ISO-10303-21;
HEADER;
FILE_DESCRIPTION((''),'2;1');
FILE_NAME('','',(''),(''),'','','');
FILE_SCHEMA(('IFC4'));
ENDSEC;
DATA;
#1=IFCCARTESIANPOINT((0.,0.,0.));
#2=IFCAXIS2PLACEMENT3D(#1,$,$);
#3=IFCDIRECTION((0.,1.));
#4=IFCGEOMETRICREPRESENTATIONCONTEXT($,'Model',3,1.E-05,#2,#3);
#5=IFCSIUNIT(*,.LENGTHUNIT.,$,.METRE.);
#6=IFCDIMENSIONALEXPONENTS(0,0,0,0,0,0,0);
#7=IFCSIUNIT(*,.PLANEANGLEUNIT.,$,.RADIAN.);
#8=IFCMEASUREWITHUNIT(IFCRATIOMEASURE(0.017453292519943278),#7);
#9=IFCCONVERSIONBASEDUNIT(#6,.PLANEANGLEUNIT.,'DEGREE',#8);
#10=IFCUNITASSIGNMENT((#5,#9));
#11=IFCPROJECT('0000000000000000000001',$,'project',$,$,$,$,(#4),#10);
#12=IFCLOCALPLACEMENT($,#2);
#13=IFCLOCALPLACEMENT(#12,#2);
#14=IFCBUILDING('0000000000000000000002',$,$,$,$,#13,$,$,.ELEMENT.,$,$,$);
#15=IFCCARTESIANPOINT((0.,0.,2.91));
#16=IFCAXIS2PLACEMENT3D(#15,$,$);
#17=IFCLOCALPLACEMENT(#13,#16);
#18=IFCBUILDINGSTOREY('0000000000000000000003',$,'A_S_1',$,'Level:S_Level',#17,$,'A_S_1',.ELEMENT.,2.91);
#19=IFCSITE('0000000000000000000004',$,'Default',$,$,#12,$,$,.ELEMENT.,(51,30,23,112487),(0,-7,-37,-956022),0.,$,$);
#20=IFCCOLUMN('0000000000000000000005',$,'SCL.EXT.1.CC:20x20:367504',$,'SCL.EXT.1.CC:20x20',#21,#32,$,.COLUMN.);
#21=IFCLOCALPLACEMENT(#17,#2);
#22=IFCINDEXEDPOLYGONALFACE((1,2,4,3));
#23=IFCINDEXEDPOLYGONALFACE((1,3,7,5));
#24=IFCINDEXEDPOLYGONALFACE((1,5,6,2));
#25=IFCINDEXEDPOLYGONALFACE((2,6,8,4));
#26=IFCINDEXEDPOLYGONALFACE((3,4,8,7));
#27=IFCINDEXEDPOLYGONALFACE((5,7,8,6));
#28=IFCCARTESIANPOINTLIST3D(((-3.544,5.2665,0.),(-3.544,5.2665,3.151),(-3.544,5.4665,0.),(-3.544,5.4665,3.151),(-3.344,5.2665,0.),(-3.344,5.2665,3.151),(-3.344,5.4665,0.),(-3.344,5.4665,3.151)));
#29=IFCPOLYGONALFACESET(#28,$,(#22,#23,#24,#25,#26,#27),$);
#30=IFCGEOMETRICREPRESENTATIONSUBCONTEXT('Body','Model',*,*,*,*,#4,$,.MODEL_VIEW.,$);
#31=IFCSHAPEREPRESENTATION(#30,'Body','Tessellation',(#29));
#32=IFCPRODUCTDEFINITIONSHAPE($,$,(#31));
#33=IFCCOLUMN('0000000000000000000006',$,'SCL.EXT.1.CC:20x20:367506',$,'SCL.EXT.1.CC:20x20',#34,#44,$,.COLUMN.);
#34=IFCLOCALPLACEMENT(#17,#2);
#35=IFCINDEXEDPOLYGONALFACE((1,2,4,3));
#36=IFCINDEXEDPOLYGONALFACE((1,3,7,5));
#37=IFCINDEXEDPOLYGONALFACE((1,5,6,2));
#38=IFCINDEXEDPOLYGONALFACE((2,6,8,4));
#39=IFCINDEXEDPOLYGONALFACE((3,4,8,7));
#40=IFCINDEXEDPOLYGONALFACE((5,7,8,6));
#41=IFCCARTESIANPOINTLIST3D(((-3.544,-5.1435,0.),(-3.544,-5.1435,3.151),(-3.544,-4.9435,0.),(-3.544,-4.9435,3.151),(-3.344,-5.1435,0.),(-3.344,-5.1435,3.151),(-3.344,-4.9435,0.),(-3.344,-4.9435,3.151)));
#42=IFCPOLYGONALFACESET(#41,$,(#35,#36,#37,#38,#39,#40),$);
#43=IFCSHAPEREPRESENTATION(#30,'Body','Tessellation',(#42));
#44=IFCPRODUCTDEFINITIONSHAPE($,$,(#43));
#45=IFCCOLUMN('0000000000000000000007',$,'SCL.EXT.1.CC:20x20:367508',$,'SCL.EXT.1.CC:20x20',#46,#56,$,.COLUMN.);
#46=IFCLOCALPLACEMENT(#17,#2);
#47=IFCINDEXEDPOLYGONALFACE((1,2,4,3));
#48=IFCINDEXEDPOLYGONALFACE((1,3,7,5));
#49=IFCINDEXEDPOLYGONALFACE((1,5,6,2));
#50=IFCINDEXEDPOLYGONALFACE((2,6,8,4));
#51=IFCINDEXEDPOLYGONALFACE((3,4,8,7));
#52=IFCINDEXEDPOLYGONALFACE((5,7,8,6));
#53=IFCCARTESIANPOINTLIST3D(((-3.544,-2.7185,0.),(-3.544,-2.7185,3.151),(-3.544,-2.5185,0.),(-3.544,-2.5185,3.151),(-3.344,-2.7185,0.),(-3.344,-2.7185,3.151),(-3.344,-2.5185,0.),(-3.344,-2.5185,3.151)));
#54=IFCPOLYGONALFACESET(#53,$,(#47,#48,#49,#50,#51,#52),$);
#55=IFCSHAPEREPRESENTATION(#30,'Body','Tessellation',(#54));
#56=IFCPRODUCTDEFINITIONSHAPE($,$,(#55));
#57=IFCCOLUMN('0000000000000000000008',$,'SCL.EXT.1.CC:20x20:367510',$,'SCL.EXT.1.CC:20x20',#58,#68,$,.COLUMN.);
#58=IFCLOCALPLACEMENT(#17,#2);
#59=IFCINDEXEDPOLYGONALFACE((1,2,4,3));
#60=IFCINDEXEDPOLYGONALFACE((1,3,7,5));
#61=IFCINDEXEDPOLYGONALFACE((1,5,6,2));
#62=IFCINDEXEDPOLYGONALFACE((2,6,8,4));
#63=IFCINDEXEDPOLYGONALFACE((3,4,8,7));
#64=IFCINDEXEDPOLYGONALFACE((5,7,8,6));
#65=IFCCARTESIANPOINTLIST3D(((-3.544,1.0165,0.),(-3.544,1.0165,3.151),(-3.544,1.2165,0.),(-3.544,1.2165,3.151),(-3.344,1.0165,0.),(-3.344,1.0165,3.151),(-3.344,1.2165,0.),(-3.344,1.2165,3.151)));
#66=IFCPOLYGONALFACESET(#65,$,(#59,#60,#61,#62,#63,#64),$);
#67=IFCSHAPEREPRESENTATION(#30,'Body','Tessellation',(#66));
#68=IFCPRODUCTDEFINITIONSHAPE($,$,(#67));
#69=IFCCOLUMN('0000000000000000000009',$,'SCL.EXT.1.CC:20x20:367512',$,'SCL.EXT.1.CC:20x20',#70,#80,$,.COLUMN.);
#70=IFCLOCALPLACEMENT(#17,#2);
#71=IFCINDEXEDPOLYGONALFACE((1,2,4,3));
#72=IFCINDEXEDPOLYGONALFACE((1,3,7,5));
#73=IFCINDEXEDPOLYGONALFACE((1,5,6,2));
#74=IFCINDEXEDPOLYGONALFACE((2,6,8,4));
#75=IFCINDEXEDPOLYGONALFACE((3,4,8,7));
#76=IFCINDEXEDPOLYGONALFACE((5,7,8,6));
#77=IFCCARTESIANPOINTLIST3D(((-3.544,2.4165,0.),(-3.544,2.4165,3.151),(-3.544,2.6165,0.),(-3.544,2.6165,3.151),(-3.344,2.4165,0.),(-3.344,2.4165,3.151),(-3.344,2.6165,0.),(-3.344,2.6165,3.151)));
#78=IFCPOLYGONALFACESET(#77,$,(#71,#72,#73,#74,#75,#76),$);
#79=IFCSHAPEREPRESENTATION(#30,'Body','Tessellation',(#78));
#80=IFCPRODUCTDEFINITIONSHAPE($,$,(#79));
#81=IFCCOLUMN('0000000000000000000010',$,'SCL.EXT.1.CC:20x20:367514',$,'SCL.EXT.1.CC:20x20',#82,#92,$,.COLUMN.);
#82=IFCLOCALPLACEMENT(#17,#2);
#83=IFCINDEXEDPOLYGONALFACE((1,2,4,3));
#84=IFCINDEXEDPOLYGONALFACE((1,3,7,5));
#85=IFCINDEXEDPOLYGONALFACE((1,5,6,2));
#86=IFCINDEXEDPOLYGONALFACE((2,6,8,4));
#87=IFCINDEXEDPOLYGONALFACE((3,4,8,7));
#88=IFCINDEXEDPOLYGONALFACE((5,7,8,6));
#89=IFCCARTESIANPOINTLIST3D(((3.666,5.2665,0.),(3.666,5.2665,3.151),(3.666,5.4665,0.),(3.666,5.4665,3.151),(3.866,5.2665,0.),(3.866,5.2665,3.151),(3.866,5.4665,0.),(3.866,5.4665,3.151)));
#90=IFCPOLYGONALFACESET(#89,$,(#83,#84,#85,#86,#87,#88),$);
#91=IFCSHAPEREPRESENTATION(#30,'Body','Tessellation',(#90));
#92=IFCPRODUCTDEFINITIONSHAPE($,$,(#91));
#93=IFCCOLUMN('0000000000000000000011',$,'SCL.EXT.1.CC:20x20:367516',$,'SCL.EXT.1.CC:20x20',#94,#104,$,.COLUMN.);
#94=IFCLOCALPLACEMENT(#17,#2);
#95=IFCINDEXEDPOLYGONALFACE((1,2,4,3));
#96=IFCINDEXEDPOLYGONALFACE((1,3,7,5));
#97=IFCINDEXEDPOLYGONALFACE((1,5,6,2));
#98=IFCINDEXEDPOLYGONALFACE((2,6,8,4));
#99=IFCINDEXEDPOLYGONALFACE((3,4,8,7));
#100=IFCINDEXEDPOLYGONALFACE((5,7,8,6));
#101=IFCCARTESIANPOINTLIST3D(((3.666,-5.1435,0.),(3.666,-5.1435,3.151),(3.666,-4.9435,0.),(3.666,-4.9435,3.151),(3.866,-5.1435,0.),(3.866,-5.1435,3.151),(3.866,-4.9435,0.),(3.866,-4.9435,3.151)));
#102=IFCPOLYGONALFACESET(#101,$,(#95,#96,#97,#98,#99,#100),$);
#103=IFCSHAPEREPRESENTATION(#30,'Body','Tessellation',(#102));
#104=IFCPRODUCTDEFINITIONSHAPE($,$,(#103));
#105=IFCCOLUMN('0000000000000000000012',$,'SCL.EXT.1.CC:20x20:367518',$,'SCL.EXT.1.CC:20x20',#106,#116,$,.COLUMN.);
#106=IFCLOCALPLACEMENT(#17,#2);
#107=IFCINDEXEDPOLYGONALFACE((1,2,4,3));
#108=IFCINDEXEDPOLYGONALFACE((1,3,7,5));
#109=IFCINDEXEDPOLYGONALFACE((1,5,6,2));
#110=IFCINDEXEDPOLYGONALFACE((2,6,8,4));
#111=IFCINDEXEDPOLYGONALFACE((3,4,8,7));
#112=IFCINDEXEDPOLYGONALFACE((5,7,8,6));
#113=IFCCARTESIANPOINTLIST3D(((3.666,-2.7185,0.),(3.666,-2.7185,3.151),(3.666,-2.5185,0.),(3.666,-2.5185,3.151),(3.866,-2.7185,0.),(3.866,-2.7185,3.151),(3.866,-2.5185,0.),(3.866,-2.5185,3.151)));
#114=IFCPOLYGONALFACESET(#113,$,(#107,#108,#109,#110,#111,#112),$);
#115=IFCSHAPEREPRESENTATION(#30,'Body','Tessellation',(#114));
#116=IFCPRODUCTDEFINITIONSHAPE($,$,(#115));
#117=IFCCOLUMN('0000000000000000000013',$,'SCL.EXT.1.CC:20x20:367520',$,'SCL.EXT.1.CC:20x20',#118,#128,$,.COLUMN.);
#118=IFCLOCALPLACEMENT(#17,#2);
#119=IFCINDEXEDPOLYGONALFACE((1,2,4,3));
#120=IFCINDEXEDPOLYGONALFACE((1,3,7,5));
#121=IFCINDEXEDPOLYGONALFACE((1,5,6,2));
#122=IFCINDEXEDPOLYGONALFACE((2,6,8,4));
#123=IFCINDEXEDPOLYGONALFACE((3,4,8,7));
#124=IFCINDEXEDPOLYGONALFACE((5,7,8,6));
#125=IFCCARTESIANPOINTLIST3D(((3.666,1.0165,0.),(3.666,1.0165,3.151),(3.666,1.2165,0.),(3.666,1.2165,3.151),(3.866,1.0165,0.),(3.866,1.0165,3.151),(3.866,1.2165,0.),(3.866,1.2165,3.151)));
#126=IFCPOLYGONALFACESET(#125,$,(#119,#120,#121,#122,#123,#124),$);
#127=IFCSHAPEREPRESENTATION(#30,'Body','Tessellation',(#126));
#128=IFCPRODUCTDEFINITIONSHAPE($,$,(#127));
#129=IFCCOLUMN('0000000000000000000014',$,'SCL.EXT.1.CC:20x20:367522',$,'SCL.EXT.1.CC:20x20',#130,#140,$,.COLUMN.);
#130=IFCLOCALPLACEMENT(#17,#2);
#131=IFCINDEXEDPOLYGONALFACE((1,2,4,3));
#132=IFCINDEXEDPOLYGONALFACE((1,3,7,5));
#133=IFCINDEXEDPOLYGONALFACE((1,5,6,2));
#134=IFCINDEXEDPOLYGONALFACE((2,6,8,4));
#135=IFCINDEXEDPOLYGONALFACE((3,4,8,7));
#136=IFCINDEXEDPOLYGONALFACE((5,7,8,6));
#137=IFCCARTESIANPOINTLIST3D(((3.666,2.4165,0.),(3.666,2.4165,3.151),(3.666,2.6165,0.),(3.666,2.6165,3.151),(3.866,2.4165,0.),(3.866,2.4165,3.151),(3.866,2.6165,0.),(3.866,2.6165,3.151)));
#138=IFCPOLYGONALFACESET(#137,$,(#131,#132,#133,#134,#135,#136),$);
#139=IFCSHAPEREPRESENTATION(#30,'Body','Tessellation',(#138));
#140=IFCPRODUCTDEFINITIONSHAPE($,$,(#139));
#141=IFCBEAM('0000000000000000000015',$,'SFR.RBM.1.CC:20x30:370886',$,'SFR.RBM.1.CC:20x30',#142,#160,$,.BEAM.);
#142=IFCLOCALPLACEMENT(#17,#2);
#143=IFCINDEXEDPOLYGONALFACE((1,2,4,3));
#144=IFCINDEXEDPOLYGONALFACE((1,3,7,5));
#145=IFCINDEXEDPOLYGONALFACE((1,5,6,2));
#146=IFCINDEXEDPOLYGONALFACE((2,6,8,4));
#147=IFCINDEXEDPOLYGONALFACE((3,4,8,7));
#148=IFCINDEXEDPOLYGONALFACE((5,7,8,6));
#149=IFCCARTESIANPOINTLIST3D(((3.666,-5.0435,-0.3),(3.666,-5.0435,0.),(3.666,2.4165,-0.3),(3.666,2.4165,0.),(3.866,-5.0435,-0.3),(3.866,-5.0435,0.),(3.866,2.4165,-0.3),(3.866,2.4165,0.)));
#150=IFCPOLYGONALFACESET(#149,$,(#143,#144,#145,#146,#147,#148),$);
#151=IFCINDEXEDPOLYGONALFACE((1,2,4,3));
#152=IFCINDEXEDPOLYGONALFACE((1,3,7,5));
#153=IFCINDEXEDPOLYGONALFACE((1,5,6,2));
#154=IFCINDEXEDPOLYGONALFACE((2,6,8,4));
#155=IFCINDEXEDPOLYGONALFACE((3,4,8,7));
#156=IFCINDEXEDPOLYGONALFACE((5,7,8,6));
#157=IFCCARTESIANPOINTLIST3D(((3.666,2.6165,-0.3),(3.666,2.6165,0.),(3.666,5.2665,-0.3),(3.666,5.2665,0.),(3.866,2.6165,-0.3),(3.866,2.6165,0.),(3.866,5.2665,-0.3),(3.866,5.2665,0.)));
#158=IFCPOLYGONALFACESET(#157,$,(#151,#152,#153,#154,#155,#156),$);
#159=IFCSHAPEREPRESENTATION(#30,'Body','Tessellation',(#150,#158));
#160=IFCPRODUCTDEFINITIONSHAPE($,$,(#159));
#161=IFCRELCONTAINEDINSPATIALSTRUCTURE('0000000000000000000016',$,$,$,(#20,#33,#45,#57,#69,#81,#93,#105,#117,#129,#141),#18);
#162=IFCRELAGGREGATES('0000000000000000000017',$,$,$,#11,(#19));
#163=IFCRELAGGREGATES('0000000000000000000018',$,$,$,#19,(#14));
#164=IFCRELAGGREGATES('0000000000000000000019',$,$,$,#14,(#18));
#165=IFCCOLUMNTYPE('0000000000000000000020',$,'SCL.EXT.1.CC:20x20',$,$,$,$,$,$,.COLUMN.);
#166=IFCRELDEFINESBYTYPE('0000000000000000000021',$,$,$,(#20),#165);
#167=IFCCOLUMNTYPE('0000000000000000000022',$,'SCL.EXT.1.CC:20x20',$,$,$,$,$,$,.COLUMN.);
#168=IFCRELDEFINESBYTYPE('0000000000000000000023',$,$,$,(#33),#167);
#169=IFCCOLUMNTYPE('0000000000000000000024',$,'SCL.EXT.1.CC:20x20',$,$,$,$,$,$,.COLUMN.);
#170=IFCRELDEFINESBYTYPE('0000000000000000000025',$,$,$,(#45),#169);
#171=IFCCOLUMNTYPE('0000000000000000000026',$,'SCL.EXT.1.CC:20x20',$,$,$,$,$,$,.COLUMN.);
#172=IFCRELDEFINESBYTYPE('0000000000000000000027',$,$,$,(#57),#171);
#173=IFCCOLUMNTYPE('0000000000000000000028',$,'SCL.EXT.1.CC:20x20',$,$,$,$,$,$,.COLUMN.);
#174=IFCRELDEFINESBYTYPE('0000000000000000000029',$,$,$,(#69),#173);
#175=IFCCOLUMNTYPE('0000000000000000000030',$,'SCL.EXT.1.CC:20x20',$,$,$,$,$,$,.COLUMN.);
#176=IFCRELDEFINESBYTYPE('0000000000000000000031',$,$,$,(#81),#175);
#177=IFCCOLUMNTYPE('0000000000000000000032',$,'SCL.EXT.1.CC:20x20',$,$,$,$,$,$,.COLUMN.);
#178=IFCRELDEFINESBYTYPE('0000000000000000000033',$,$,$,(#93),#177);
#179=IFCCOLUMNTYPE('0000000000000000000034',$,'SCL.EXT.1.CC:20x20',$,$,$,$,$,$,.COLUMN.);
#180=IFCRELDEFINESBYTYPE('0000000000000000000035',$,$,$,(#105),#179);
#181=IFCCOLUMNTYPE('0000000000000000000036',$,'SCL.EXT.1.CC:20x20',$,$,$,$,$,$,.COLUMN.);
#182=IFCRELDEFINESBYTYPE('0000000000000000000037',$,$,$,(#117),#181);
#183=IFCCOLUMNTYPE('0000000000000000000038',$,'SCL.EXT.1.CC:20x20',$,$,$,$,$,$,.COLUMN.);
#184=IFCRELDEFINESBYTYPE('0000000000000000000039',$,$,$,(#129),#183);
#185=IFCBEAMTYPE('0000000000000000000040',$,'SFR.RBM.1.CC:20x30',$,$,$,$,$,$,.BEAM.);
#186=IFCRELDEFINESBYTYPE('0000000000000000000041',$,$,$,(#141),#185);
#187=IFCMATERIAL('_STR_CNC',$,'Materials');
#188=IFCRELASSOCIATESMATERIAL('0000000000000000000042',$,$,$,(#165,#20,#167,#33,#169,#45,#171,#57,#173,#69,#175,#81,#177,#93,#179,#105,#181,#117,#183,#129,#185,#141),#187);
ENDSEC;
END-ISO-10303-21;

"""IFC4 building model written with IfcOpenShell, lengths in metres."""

from ifc_helpers import new_model, entity, si_unit, converted_unit, direction, frame, origin, place, context, subcontext, project, spatial, indexed_curve, outline, extrude, source, transform, mapped, material, type_object, type_shapes, element, save


model = new_model("IFC4")

# Units and contexts
model_context = context("Model", 3, precision=1e-05, world=origin(), true_north=direction((0.0, 1.0)))
body_context = subcontext(model_context, "Body", "Model", "MODEL_VIEW")
ifc_project = project(units=[si_unit("LENGTHUNIT", "METRE"), converted_unit("PLANEANGLEUNIT", "DEGREE", entity("IfcRatioMeasure", 0.017453292519943278), si_unit("PLANEANGLEUNIT", "RADIAN"), dimensions=[0, 0, 0, 0, 0, 0, 0])], contexts=[model_context])

# Site, building, storey
site_placement = place(None, origin())
site = spatial("IfcSite", under=ifc_project, at=site_placement, Name="Default", CompositionType="ELEMENT", RefLatitude=(51, 30, 23, 112487), RefLongitude=(0, -7, -37, -956022), RefElevation=0.0)
building_placement = place(site_placement, origin())
building = spatial("IfcBuilding", under=site, at=building_placement, CompositionType="ELEMENT")
storey_placement = place(building_placement, frame((0.0, 0.0, 2.91)))
storey = spatial("IfcBuildingStorey", under=building, at=storey_placement, Name="A_S_1", ObjectType="Level:S_Level", LongName="A_S_1", CompositionType="ELEMENT", Elevation=2.91)

# Columns
ifc_material_1 = material(Name="_STR_CNC", Category="Materials")
column_type_1 = type_object("IfcColumnType", Name="SCL.EXT.1.CC:20x20", PredefinedType="COLUMN", material=ifc_material_1)
shared_shape_1 = source(origin(), body_context, "Body", "SweptSolid", [
    extrude(outline(indexed_curve([(-0.1, -0.1), (0.1, -0.1), (0.1, 0.1), (-0.1, 0.1), (-0.1, -0.1)], self_intersect=False)), frame((-3.444, 5.3665, 2.91), z_axis=(0.0, 0.0, 1.0), x_axis=(0.0, -1.0, 0.0)), (0.0, 0.0, 1.0), 3.151),
])
type_shapes(column_type_1, [shared_shape_1])
column_1_placement = place(storey_placement, frame((0.0, 0.0, -2.91)))
element("IfcColumn", 1, at=column_1_placement, inside=storey, type_object=column_type_1, material=ifc_material_1, Name="SCL.EXT.1.CC:20x20:367504", ObjectType="SCL.EXT.1.CC:20x20", PredefinedType="COLUMN", context=body_context, shape_type="MappedRepresentation", body=[
    mapped(shared_shape_1, transform((0.0, 0.0, 0.0), scale=1.0)),
])
column_type_2 = type_object("IfcColumnType", Name="SCL.EXT.1.CC:20x20", PredefinedType="COLUMN", material=ifc_material_1)
shared_shape_2 = source(origin(), body_context, "Body", "SweptSolid", [
    extrude(outline(indexed_curve([(-0.1, -0.1), (0.1, -0.1), (0.1, 0.1), (-0.1, 0.1), (-0.1, -0.1)], self_intersect=False)), frame((-3.444, -5.0435, 2.91), z_axis=(0.0, 0.0, 1.0), x_axis=(0.0, -1.0, 0.0)), (0.0, 0.0, 1.0), 3.151),
])
type_shapes(column_type_2, [shared_shape_2])
column_2_placement = place(storey_placement, frame((0.0, 0.0, -2.91)))
element("IfcColumn", 2, at=column_2_placement, inside=storey, type_object=column_type_2, material=ifc_material_1, Name="SCL.EXT.1.CC:20x20:367506", ObjectType="SCL.EXT.1.CC:20x20", PredefinedType="COLUMN", context=body_context, shape_type="MappedRepresentation", body=[
    mapped(shared_shape_2, transform((0.0, 0.0, 0.0), scale=1.0)),
])
column_type_3 = type_object("IfcColumnType", Name="SCL.EXT.1.CC:20x20", PredefinedType="COLUMN", material=ifc_material_1)
shared_shape_3 = source(origin(), body_context, "Body", "SweptSolid", [
    extrude(outline(indexed_curve([(-0.1, -0.1), (0.1, -0.1), (0.1, 0.1), (-0.1, 0.1), (-0.1, -0.1)], self_intersect=False)), frame((-3.444, -2.6185, 2.91), z_axis=(0.0, 0.0, 1.0), x_axis=(0.0, -1.0, 0.0)), (0.0, 0.0, 1.0), 3.151),
])
type_shapes(column_type_3, [shared_shape_3])
column_3_placement = place(storey_placement, frame((0.0, 0.0, -2.91)))
element("IfcColumn", 3, at=column_3_placement, inside=storey, type_object=column_type_3, material=ifc_material_1, Name="SCL.EXT.1.CC:20x20:367508", ObjectType="SCL.EXT.1.CC:20x20", PredefinedType="COLUMN", context=body_context, shape_type="MappedRepresentation", body=[
    mapped(shared_shape_3, transform((0.0, 0.0, 0.0), scale=1.0)),
])
column_type_4 = type_object("IfcColumnType", Name="SCL.EXT.1.CC:20x20", PredefinedType="COLUMN", material=ifc_material_1)
shared_shape_4 = source(origin(), body_context, "Body", "SweptSolid", [
    extrude(outline(indexed_curve([(-0.1, -0.1), (0.1, -0.1), (0.1, 0.1), (-0.1, 0.1), (-0.1, -0.1)], self_intersect=False)), frame((-3.444, 1.1165, 2.91), z_axis=(0.0, 0.0, 1.0), x_axis=(0.0, -1.0, 0.0)), (0.0, 0.0, 1.0), 3.151),
])
type_shapes(column_type_4, [shared_shape_4])
column_4_placement = place(storey_placement, frame((0.0, 0.0, -2.91)))
element("IfcColumn", 4, at=column_4_placement, inside=storey, type_object=column_type_4, material=ifc_material_1, Name="SCL.EXT.1.CC:20x20:367510", ObjectType="SCL.EXT.1.CC:20x20", PredefinedType="COLUMN", context=body_context, shape_type="MappedRepresentation", body=[
    mapped(shared_shape_4, transform((0.0, 0.0, 0.0), scale=1.0)),
])
column_type_5 = type_object("IfcColumnType", Name="SCL.EXT.1.CC:20x20", PredefinedType="COLUMN", material=ifc_material_1)
shared_shape_5 = source(origin(), body_context, "Body", "SweptSolid", [
    extrude(outline(indexed_curve([(-0.1, -0.1), (0.1, -0.1), (0.1, 0.1), (-0.1, 0.1), (-0.1, -0.1)], self_intersect=False)), frame((-3.444, 2.5165, 2.91), z_axis=(0.0, 0.0, 1.0), x_axis=(0.0, -1.0, 0.0)), (0.0, 0.0, 1.0), 3.151),
])
type_shapes(column_type_5, [shared_shape_5])
column_5_placement = place(storey_placement, frame((0.0, 0.0, -2.91)))
element("IfcColumn", 5, at=column_5_placement, inside=storey, type_object=column_type_5, material=ifc_material_1, Name="SCL.EXT.1.CC:20x20:367512", ObjectType="SCL.EXT.1.CC:20x20", PredefinedType="COLUMN", context=body_context, shape_type="MappedRepresentation", body=[
    mapped(shared_shape_5, transform((0.0, 0.0, 0.0), scale=1.0)),
])
column_type_6 = type_object("IfcColumnType", Name="SCL.EXT.1.CC:20x20", PredefinedType="COLUMN", material=ifc_material_1)
shared_shape_6 = source(origin(), body_context, "Body", "SweptSolid", [
    extrude(outline(indexed_curve([(-0.1, -0.1), (0.1, -0.1), (0.1, 0.1), (-0.1, 0.1), (-0.1, -0.1)], self_intersect=False)), frame((3.766, 5.3665, 2.91), z_axis=(0.0, 0.0, 1.0), x_axis=(0.0, -1.0, 0.0)), (0.0, 0.0, 1.0), 3.151),
])
type_shapes(column_type_6, [shared_shape_6])
column_6_placement = place(storey_placement, frame((0.0, 0.0, -2.91)))
element("IfcColumn", 6, at=column_6_placement, inside=storey, type_object=column_type_6, material=ifc_material_1, Name="SCL.EXT.1.CC:20x20:367514", ObjectType="SCL.EXT.1.CC:20x20", PredefinedType="COLUMN", context=body_context, shape_type="MappedRepresentation", body=[
    mapped(shared_shape_6, transform((0.0, 0.0, 0.0), scale=1.0)),
])
column_type_7 = type_object("IfcColumnType", Name="SCL.EXT.1.CC:20x20", PredefinedType="COLUMN", material=ifc_material_1)
shared_shape_7 = source(origin(), body_context, "Body", "SweptSolid", [
    extrude(outline(indexed_curve([(-0.1, -0.1), (0.1, -0.1), (0.1, 0.1), (-0.1, 0.1), (-0.1, -0.1)], self_intersect=False)), frame((3.766, -5.0435, 2.91), z_axis=(0.0, 0.0, 1.0), x_axis=(0.0, -1.0, 0.0)), (0.0, 0.0, 1.0), 3.151),
])
type_shapes(column_type_7, [shared_shape_7])
column_7_placement = place(storey_placement, frame((0.0, 0.0, -2.91)))
element("IfcColumn", 7, at=column_7_placement, inside=storey, type_object=column_type_7, material=ifc_material_1, Name="SCL.EXT.1.CC:20x20:367516", ObjectType="SCL.EXT.1.CC:20x20", PredefinedType="COLUMN", context=body_context, shape_type="MappedRepresentation", body=[
    mapped(shared_shape_7, transform((0.0, 0.0, 0.0), scale=1.0)),
])
column_type_8 = type_object("IfcColumnType", Name="SCL.EXT.1.CC:20x20", PredefinedType="COLUMN", material=ifc_material_1)
shared_shape_8 = source(origin(), body_context, "Body", "SweptSolid", [
    extrude(outline(indexed_curve([(-0.1, -0.1), (0.1, -0.1), (0.1, 0.1), (-0.1, 0.1), (-0.1, -0.1)], self_intersect=False)), frame((3.766, -2.6185, 2.91), z_axis=(0.0, 0.0, 1.0), x_axis=(0.0, -1.0, 0.0)), (0.0, 0.0, 1.0), 3.151),
])
type_shapes(column_type_8, [shared_shape_8])
column_8_placement = place(storey_placement, frame((0.0, 0.0, -2.91)))
element("IfcColumn", 8, at=column_8_placement, inside=storey, type_object=column_type_8, material=ifc_material_1, Name="SCL.EXT.1.CC:20x20:367518", ObjectType="SCL.EXT.1.CC:20x20", PredefinedType="COLUMN", context=body_context, shape_type="MappedRepresentation", body=[
    mapped(shared_shape_8, transform((0.0, 0.0, 0.0), scale=1.0)),
])
column_type_9 = type_object("IfcColumnType", Name="SCL.EXT.1.CC:20x20", PredefinedType="COLUMN", material=ifc_material_1)
shared_shape_9 = source(origin(), body_context, "Body", "SweptSolid", [
    extrude(outline(indexed_curve([(-0.1, -0.1), (0.1, -0.1), (0.1, 0.1), (-0.1, 0.1), (-0.1, -0.1)], self_intersect=False)), frame((3.766, 1.1165, 2.91), z_axis=(0.0, 0.0, 1.0), x_axis=(0.0, -1.0, 0.0)), (0.0, 0.0, 1.0), 3.151),
])
type_shapes(column_type_9, [shared_shape_9])
column_9_placement = place(storey_placement, frame((0.0, 0.0, -2.91)))
element("IfcColumn", 9, at=column_9_placement, inside=storey, type_object=column_type_9, material=ifc_material_1, Name="SCL.EXT.1.CC:20x20:367520", ObjectType="SCL.EXT.1.CC:20x20", PredefinedType="COLUMN", context=body_context, shape_type="MappedRepresentation", body=[
    mapped(shared_shape_9, transform((0.0, 0.0, 0.0), scale=1.0)),
])
column_type_10 = type_object("IfcColumnType", Name="SCL.EXT.1.CC:20x20", PredefinedType="COLUMN", material=ifc_material_1)
shared_shape_10 = source(origin(), body_context, "Body", "SweptSolid", [
    extrude(outline(indexed_curve([(-0.1, -0.1), (0.1, -0.1), (0.1, 0.1), (-0.1, 0.1), (-0.1, -0.1)], self_intersect=False)), frame((3.766, 2.5165, 2.91), z_axis=(0.0, 0.0, 1.0), x_axis=(0.0, -1.0, 0.0)), (0.0, 0.0, 1.0), 3.151),
])
type_shapes(column_type_10, [shared_shape_10])
column_10_placement = place(storey_placement, frame((0.0, 0.0, -2.91)))
element("IfcColumn", 10, at=column_10_placement, inside=storey, type_object=column_type_10, material=ifc_material_1, Name="SCL.EXT.1.CC:20x20:367522", ObjectType="SCL.EXT.1.CC:20x20", PredefinedType="COLUMN", context=body_context, shape_type="MappedRepresentation", body=[
    mapped(shared_shape_10, transform((0.0, 0.0, 0.0), scale=1.0)),
])

# Beam
beam_type_1 = type_object("IfcBeamType", Name="SFR.RBM.1.CC:20x30", PredefinedType="BEAM", material=ifc_material_1)
shared_shape_11 = source(origin(), body_context, "Body", "SweptSolid", [
    extrude(outline(indexed_curve([(-0.1, -0.15), (0.1, -0.15), (0.1, 0.15), (-0.1, 0.15), (-0.1, -0.15)], self_intersect=False)), frame((3.766, 2.4165, 2.76), z_axis=(0.0, -1.0, 0.0), x_axis=(-1.0, 0.0, 0.0)), (0.0, 0.0, 1.0), 7.46),
    extrude(outline(indexed_curve([(-0.1, -0.15), (0.1, -0.15), (0.1, 0.15), (-0.1, 0.15), (-0.1, -0.15)], self_intersect=False)), frame((3.766, 5.2665, 2.76), z_axis=(0.0, -1.0, 0.0), x_axis=(-1.0, 0.0, 0.0)), (0.0, 0.0, 1.0), 2.65),
])
type_shapes(beam_type_1, [shared_shape_11])
beam_1_placement = place(storey_placement, frame((0.0, 0.0, -2.91)))
element("IfcBeam", 11, at=beam_1_placement, inside=storey, type_object=beam_type_1, material=ifc_material_1, Name="SFR.RBM.1.CC:20x30:370886", ObjectType="SFR.RBM.1.CC:20x30", PredefinedType="BEAM", context=body_context, shape_type="MappedRepresentation", body=[
    mapped(shared_shape_11, transform((0.0, 0.0, 0.0), scale=1.0)),
])

save(model, "model.ifc")
